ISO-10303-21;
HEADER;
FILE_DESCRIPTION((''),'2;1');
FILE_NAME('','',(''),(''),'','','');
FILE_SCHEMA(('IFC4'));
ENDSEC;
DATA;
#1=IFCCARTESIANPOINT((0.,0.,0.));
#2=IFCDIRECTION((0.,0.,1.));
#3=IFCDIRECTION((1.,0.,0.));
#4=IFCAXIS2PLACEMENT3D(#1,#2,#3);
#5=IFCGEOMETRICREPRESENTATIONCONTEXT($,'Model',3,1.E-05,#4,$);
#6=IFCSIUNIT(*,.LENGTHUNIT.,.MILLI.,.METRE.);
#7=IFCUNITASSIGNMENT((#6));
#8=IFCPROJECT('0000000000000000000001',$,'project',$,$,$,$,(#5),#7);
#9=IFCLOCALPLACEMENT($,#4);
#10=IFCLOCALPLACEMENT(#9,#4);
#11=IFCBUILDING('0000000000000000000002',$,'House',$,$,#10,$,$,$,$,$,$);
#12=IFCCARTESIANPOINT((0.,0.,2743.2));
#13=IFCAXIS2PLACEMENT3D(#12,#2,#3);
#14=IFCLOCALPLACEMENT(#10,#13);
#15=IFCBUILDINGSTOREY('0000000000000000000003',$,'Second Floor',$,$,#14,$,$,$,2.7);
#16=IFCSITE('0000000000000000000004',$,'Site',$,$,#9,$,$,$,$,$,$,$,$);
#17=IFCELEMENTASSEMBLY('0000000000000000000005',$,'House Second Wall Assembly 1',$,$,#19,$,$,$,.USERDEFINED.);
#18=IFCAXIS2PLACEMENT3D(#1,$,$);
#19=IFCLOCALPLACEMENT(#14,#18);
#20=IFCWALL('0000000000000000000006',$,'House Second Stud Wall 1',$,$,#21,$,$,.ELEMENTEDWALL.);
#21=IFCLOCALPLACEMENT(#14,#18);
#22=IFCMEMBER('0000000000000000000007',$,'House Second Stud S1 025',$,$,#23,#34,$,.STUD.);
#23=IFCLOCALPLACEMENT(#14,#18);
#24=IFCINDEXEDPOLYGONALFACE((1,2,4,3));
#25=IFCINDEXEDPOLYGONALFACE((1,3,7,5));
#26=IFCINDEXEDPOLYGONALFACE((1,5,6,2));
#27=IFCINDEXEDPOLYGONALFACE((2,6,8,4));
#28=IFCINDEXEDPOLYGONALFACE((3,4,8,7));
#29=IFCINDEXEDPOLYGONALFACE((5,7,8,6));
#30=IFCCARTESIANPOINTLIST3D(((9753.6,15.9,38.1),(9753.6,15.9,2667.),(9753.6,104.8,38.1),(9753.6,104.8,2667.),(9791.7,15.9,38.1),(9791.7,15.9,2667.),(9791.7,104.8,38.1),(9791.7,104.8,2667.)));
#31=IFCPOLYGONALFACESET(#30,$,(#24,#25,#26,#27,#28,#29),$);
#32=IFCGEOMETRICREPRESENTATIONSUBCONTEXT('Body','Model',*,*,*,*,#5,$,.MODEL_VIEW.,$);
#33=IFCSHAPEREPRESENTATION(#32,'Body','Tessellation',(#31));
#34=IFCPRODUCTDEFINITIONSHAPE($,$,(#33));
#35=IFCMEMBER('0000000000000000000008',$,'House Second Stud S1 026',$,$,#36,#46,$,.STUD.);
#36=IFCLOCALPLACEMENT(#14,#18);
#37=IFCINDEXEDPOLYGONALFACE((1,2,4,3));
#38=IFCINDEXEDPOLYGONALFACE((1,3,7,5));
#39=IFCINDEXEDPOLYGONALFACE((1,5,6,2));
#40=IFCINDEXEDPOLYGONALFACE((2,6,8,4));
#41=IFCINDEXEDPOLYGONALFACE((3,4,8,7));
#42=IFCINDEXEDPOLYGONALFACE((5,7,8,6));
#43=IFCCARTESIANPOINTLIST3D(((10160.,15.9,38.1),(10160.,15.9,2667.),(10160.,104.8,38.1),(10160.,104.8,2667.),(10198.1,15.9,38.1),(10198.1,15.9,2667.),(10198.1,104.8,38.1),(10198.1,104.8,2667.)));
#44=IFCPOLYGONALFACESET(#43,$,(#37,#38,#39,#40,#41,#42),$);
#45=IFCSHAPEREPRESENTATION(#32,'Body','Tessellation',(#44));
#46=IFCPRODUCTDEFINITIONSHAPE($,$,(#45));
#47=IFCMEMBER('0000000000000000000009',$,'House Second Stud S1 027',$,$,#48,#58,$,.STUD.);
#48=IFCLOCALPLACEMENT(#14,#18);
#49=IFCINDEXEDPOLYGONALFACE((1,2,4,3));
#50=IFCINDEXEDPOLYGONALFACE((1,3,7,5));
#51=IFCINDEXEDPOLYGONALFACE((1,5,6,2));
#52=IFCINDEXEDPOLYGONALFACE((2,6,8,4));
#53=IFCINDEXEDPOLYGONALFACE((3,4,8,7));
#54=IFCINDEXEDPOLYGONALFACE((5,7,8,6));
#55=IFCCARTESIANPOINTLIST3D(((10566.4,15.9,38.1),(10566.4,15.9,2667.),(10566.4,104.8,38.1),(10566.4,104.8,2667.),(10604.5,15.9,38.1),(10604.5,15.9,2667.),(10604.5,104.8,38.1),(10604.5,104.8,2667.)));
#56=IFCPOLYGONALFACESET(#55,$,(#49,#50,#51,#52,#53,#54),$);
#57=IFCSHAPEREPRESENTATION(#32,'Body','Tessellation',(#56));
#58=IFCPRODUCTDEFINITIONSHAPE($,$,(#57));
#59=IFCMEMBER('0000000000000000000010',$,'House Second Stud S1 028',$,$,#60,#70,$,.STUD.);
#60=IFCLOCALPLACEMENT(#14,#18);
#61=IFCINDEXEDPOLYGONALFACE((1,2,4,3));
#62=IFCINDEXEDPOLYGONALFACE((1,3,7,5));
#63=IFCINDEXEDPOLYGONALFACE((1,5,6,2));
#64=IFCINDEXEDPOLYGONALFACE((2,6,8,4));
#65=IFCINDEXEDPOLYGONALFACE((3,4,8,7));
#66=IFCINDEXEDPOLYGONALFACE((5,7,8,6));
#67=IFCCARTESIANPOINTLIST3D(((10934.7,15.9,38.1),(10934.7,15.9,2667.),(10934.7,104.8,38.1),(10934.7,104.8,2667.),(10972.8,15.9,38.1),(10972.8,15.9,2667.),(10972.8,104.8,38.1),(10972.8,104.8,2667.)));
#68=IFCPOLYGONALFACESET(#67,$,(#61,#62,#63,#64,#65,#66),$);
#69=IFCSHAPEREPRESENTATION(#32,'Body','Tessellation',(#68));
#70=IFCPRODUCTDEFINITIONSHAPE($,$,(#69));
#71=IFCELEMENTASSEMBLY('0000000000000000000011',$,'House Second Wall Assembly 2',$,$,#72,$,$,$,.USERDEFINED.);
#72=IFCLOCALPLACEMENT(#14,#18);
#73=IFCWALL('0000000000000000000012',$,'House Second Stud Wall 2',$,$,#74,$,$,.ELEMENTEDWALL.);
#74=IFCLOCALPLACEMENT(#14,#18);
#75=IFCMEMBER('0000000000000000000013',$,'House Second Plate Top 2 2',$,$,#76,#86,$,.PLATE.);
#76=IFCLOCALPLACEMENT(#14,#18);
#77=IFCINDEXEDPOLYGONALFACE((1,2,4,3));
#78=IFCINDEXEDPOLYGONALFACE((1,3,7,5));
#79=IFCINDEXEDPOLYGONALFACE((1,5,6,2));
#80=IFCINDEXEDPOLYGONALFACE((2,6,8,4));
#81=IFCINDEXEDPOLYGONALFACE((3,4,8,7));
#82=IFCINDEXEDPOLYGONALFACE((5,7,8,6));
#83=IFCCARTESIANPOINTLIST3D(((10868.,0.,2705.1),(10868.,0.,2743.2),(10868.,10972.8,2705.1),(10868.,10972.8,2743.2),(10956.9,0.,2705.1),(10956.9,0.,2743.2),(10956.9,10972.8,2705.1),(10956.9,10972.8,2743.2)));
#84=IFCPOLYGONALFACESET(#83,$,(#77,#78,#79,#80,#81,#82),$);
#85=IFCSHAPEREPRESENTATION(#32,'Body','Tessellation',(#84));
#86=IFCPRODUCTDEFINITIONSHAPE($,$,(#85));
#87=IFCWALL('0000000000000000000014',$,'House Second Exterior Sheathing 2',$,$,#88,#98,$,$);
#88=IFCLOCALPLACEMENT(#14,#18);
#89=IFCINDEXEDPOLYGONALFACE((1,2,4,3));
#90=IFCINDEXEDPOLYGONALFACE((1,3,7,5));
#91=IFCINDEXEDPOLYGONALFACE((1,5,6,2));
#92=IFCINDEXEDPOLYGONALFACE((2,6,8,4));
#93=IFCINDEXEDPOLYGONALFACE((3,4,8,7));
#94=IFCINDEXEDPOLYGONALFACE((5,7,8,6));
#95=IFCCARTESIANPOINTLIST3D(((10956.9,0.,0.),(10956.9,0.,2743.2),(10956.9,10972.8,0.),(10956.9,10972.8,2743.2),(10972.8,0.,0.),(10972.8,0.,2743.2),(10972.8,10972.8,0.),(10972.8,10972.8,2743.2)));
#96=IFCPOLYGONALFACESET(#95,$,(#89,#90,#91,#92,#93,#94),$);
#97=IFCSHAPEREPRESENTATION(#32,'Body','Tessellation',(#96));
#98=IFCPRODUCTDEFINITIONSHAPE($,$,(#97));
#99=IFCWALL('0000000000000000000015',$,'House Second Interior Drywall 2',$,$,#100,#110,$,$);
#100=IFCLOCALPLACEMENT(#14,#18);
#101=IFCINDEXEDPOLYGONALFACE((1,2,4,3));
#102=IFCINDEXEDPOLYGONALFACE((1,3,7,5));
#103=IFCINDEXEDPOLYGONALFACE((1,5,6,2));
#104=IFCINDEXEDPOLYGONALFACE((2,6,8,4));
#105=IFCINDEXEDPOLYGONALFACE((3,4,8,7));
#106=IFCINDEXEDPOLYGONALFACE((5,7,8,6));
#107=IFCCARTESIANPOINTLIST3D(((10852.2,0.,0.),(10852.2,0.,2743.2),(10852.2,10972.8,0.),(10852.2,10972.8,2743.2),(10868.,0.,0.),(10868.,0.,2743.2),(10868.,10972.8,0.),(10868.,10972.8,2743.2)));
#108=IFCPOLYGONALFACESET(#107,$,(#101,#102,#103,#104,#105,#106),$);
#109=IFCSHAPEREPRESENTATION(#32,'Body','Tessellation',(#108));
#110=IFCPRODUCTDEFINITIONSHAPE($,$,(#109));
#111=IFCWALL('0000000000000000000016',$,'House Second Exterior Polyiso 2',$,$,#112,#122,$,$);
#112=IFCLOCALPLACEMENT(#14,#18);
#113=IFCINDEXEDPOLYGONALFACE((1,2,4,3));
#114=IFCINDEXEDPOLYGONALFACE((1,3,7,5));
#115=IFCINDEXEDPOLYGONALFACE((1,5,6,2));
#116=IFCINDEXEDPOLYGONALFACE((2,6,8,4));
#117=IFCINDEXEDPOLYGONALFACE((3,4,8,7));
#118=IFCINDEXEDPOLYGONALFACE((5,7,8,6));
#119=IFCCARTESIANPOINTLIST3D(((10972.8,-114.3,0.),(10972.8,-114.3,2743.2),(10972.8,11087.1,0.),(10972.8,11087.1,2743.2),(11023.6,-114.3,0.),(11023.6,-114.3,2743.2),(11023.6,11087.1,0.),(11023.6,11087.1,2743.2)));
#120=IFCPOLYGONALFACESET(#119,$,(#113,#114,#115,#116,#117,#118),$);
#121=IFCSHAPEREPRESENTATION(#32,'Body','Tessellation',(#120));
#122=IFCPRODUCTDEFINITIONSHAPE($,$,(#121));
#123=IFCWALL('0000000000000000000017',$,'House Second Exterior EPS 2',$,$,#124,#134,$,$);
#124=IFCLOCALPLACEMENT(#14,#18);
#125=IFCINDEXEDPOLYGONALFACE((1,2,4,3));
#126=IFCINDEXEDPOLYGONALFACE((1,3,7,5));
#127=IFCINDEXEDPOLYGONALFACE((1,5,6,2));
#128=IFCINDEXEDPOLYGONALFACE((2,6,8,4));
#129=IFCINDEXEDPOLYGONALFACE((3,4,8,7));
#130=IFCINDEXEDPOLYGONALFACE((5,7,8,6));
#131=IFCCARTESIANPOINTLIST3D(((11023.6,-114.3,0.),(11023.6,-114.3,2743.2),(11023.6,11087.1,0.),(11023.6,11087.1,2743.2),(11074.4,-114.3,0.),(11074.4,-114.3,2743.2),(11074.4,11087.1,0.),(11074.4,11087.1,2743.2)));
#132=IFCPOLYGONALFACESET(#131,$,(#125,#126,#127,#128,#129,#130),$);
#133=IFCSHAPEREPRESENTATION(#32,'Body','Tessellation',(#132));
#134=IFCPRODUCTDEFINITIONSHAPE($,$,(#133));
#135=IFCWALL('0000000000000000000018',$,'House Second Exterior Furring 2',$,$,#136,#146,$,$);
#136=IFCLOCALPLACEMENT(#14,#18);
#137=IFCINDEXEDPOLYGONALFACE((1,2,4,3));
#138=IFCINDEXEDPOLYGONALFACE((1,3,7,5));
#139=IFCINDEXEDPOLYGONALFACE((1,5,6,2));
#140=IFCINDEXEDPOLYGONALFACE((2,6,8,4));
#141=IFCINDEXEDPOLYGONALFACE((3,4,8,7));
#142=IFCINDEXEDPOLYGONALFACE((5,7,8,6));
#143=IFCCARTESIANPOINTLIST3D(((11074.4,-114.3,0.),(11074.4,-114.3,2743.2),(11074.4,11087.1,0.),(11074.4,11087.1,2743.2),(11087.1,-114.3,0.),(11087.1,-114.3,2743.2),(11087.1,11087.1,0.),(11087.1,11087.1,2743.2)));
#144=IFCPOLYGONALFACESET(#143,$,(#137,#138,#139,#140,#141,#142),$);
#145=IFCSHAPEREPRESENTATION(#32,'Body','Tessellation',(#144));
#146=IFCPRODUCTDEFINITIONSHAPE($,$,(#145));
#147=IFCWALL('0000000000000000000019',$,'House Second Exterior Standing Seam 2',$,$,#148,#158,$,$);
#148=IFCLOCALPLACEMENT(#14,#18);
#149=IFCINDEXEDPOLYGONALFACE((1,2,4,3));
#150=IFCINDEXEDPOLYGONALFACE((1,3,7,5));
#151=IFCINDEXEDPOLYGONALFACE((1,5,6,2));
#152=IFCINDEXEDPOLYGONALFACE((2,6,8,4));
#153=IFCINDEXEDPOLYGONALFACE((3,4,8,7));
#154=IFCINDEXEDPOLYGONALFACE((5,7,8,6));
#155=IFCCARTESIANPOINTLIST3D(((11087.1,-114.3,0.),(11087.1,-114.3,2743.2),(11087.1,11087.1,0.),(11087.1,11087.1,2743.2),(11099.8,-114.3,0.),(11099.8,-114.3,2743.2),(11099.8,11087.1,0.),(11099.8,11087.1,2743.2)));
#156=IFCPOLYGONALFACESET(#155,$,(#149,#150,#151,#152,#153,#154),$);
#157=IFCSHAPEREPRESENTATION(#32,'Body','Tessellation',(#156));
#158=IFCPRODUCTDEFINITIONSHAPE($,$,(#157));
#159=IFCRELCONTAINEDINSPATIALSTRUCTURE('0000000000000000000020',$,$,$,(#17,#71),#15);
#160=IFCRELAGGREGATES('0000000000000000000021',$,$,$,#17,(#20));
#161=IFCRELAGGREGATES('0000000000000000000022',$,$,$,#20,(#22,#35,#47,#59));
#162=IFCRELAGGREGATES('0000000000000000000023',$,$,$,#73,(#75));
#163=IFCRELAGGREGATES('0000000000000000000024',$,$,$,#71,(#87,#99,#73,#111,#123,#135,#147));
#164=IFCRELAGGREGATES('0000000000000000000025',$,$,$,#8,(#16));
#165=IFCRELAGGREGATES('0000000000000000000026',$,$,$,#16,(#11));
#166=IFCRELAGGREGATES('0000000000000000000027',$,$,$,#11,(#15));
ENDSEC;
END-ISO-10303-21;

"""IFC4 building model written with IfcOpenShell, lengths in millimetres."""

from ifc_helpers import new_model, si_unit, frame, origin_with_axes, origin_2d, place, context, subcontext, project, spatial, indexed_curve, rectangle, outline, extrude, element, aggregate, save


model = new_model("IFC4")

# Units and contexts
model_context = context("Model", 3, precision=1e-05, world=origin_with_axes())
body_context = subcontext(model_context, "Body", "Model", "MODEL_VIEW")
ifc_project = project(units=[si_unit("LENGTHUNIT", "METRE", prefix="MILLI")], contexts=[model_context])

# Site, building, storey
site_placement = place(None, origin_with_axes())
site = spatial("IfcSite", under=ifc_project, at=site_placement, Name="Site")
building_placement = place(site_placement, origin_with_axes())
building = spatial("IfcBuilding", under=site, at=building_placement, Name="House")
storey_placement = place(building_placement, frame((0.0, 0.0, 2743.2), z_axis=(0.0, 0.0, 1.0), x_axis=(1.0, 0.0, 0.0)))
storey = spatial("IfcBuildingStorey", under=building, at=storey_placement, Name="Second Floor", Elevation=2.7)

# Element assembly, wall, members
assembly_1_placement = place(storey_placement, frame((0.0, 0.0, -2743.2), z_axis=(0.0, 0.0, 1.0), x_axis=(1.0, 0.0, 0.0)))
assembly_1 = element("IfcElementAssembly", 1, at=assembly_1_placement, inside=storey, Name="House Second Wall Assembly 1", PredefinedType="USERDEFINED")
wall_1_placement = place(assembly_1_placement, frame((0.0, 0.0, 2743.2), z_axis=(0.0, 0.0, 1.0), x_axis=(1.0, 0.0, 0.0)))
wall_1 = element("IfcWall", 2, at=wall_1_placement, Name="House Second Stud Wall 1", PredefinedType="ELEMENTEDWALL")
aggregate(assembly_1, [wall_1])
member_1_placement = place(wall_1_placement, frame((9772.6, 60.3, 38.1), z_axis=(0.0, 0.0, 1.0), x_axis=(1.0, 0.0, 0.0)))
member_1 = element("IfcMember", 3, at=member_1_placement, Name="House Second Stud S1 025", PredefinedType="STUD", context=body_context, shape_type="SweptSolid", body=[
    extrude(rectangle(XDim=38.1, YDim=88.9, at=origin_2d()), origin_with_axes(), (0.0, 0.0, 1.0), 2628.9),
])
member_2_placement = place(wall_1_placement, frame((10179.0, 60.3, 38.1), z_axis=(0.0, 0.0, 1.0), x_axis=(1.0, 0.0, 0.0)))
member_2 = element("IfcMember", 4, at=member_2_placement, Name="House Second Stud S1 026", PredefinedType="STUD", context=body_context, shape_type="SweptSolid", body=[
    extrude(rectangle(XDim=38.1, YDim=88.9, at=origin_2d()), origin_with_axes(), (0.0, 0.0, 1.0), 2628.9),
])
member_3_placement = place(wall_1_placement, frame((10585.5, 60.3, 38.1), z_axis=(0.0, 0.0, 1.0), x_axis=(1.0, 0.0, 0.0)))
member_3 = element("IfcMember", 5, at=member_3_placement, Name="House Second Stud S1 027", PredefinedType="STUD", context=body_context, shape_type="SweptSolid", body=[
    extrude(rectangle(XDim=38.1, YDim=88.9, at=origin_2d()), origin_with_axes(), (0.0, 0.0, 1.0), 2628.9),
])
member_4_placement = place(wall_1_placement, frame((10953.8, 60.3, 38.1), z_axis=(0.0, 0.0, 1.0), x_axis=(1.0, 0.0, 0.0)))
member_4 = element("IfcMember", 6, at=member_4_placement, Name="House Second Stud S1 028", PredefinedType="STUD", context=body_context, shape_type="SweptSolid", body=[
    extrude(rectangle(XDim=38.1, YDim=88.9, at=origin_2d()), origin_with_axes(), (0.0, 0.0, 1.0), 2628.9),
])
aggregate(wall_1, [member_1, member_2, member_3, member_4])

# Element assembly, walls, member
assembly_2_placement = place(storey_placement, frame((0.0, 0.0, -2743.2), z_axis=(0.0, 0.0, 1.0), x_axis=(1.0, 0.0, 0.0)))
assembly_2 = element("IfcElementAssembly", 7, at=assembly_2_placement, inside=storey, Name="House Second Wall Assembly 2", PredefinedType="USERDEFINED")
wall_2_placement = place(assembly_2_placement, frame((10972.8, 0.0, 2743.2), z_axis=(0.0, 0.0, 1.0), x_axis=(0.0, 1.0, 0.0)))
wall_2 = element("IfcWall", 8, at=wall_2_placement, Name="House Second Stud Wall 2", PredefinedType="ELEMENTEDWALL")
member_5_placement = place(wall_2_placement, frame((0.0, 60.3, 2724.2), z_axis=(1.0, 0.0, 0.0), x_axis=(0.0, 0.0, 1.0)))
member_5 = element("IfcMember", 9, at=member_5_placement, Name="House Second Plate Top 2 2", PredefinedType="PLATE", context=body_context, shape_type="SweptSolid", body=[
    extrude(rectangle(XDim=38.1, YDim=88.9, at=origin_2d()), origin_with_axes(), (0.0, 0.0, 1.0), 10972.8),
])
aggregate(wall_2, [member_5])
wall_3_placement = place(assembly_2_placement, frame((10972.8, 0.0, 2743.2), z_axis=(0.0, 0.0, 1.0), x_axis=(0.0, 1.0, 0.0)))
wall_3 = element("IfcWall", 10, at=wall_3_placement, Name="House Second Exterior Sheathing 2", context=body_context, shape_type="SweptSolid", body=[
    extrude(outline(indexed_curve([(0.0, 0.0), (0.0, 15.9), (10972.8, 15.9), (10972.8, 0.0), (0.0, 0.0)], self_intersect=False)), origin_with_axes(), (0.0, 0.0, 1.0), 2743.2),
])
wall_4_placement = place(assembly_2_placement, frame((10972.8, 0.0, 2743.2), z_axis=(0.0, 0.0, 1.0), x_axis=(0.0, 1.0, 0.0)))
wall_4 = element("IfcWall", 11, at=wall_4_placement, Name="House Second Interior Drywall 2", context=body_context, shape_type="SweptSolid", body=[
    extrude(outline(indexed_curve([(0.0, 0.0), (0.0, 15.9), (10972.8, 15.9), (10972.8, 0.0), (0.0, 0.0)], self_intersect=False)), frame((0.0, 104.8, 0.0), z_axis=(0.0, 0.0, 1.0), x_axis=(1.0, 0.0, 0.0)), (0.0, 0.0, 1.0), 2743.2),
])
wall_5_placement = place(assembly_2_placement, frame((10972.8, -114.3, 2743.2), z_axis=(0.0, 0.0, 1.0), x_axis=(0.0, 1.0, 0.0)))
wall_5 = element("IfcWall", 12, at=wall_5_placement, Name="House Second Exterior Polyiso 2", context=body_context, shape_type="SweptSolid", body=[
    extrude(outline(indexed_curve([(0.0, 0.0), (0.0, -50.8), (11201.4, -50.8), (11201.4, 0.0), (0.0, 0.0)], self_intersect=False)), origin_with_axes(), (0.0, 0.0, 1.0), 2743.2),
])
wall_6_placement = place(assembly_2_placement, frame((10972.8, -114.3, 2743.2), z_axis=(0.0, 0.0, 1.0), x_axis=(0.0, 1.0, 0.0)))
wall_6 = element("IfcWall", 13, at=wall_6_placement, Name="House Second Exterior EPS 2", context=body_context, shape_type="SweptSolid", body=[
    extrude(outline(indexed_curve([(0.0, 0.0), (0.0, -50.8), (11201.4, -50.8), (11201.4, 0.0), (0.0, 0.0)], self_intersect=False)), frame((0.0, -50.8, 0.0), z_axis=(0.0, 0.0, 1.0), x_axis=(1.0, 0.0, 0.0)), (0.0, 0.0, 1.0), 2743.2),
])
wall_7_placement = place(assembly_2_placement, frame((10972.8, -114.3, 2743.2), z_axis=(0.0, 0.0, 1.0), x_axis=(0.0, 1.0, 0.0)))
wall_7 = element("IfcWall", 14, at=wall_7_placement, Name="House Second Exterior Furring 2", context=body_context, shape_type="SweptSolid", body=[
    extrude(outline(indexed_curve([(0.0, 0.0), (0.0, -12.7), (11201.4, -12.7), (11201.4, 0.0), (0.0, 0.0)], self_intersect=False)), frame((0.0, -101.6, 0.0), z_axis=(0.0, 0.0, 1.0), x_axis=(1.0, 0.0, 0.0)), (0.0, 0.0, 1.0), 2743.2),
])
wall_8_placement = place(assembly_2_placement, frame((10972.8, -114.3, 2743.2), z_axis=(0.0, 0.0, 1.0), x_axis=(0.0, 1.0, 0.0)))
wall_8 = element("IfcWall", 15, at=wall_8_placement, Name="House Second Exterior Standing Seam 2", context=body_context, shape_type="SweptSolid", body=[
    extrude(outline(indexed_curve([(0.0, 0.0), (0.0, -12.7), (11201.4, -12.7), (11201.4, 0.0), (0.0, 0.0)], self_intersect=False)), frame((0.0, -114.3, 0.0), z_axis=(0.0, 0.0, 1.0), x_axis=(1.0, 0.0, 0.0)), (0.0, 0.0, 1.0), 2743.2),
])
aggregate(assembly_2, [wall_3, wall_4, wall_2, wall_5, wall_6, wall_7, wall_8])

save(model, "model.ifc")
